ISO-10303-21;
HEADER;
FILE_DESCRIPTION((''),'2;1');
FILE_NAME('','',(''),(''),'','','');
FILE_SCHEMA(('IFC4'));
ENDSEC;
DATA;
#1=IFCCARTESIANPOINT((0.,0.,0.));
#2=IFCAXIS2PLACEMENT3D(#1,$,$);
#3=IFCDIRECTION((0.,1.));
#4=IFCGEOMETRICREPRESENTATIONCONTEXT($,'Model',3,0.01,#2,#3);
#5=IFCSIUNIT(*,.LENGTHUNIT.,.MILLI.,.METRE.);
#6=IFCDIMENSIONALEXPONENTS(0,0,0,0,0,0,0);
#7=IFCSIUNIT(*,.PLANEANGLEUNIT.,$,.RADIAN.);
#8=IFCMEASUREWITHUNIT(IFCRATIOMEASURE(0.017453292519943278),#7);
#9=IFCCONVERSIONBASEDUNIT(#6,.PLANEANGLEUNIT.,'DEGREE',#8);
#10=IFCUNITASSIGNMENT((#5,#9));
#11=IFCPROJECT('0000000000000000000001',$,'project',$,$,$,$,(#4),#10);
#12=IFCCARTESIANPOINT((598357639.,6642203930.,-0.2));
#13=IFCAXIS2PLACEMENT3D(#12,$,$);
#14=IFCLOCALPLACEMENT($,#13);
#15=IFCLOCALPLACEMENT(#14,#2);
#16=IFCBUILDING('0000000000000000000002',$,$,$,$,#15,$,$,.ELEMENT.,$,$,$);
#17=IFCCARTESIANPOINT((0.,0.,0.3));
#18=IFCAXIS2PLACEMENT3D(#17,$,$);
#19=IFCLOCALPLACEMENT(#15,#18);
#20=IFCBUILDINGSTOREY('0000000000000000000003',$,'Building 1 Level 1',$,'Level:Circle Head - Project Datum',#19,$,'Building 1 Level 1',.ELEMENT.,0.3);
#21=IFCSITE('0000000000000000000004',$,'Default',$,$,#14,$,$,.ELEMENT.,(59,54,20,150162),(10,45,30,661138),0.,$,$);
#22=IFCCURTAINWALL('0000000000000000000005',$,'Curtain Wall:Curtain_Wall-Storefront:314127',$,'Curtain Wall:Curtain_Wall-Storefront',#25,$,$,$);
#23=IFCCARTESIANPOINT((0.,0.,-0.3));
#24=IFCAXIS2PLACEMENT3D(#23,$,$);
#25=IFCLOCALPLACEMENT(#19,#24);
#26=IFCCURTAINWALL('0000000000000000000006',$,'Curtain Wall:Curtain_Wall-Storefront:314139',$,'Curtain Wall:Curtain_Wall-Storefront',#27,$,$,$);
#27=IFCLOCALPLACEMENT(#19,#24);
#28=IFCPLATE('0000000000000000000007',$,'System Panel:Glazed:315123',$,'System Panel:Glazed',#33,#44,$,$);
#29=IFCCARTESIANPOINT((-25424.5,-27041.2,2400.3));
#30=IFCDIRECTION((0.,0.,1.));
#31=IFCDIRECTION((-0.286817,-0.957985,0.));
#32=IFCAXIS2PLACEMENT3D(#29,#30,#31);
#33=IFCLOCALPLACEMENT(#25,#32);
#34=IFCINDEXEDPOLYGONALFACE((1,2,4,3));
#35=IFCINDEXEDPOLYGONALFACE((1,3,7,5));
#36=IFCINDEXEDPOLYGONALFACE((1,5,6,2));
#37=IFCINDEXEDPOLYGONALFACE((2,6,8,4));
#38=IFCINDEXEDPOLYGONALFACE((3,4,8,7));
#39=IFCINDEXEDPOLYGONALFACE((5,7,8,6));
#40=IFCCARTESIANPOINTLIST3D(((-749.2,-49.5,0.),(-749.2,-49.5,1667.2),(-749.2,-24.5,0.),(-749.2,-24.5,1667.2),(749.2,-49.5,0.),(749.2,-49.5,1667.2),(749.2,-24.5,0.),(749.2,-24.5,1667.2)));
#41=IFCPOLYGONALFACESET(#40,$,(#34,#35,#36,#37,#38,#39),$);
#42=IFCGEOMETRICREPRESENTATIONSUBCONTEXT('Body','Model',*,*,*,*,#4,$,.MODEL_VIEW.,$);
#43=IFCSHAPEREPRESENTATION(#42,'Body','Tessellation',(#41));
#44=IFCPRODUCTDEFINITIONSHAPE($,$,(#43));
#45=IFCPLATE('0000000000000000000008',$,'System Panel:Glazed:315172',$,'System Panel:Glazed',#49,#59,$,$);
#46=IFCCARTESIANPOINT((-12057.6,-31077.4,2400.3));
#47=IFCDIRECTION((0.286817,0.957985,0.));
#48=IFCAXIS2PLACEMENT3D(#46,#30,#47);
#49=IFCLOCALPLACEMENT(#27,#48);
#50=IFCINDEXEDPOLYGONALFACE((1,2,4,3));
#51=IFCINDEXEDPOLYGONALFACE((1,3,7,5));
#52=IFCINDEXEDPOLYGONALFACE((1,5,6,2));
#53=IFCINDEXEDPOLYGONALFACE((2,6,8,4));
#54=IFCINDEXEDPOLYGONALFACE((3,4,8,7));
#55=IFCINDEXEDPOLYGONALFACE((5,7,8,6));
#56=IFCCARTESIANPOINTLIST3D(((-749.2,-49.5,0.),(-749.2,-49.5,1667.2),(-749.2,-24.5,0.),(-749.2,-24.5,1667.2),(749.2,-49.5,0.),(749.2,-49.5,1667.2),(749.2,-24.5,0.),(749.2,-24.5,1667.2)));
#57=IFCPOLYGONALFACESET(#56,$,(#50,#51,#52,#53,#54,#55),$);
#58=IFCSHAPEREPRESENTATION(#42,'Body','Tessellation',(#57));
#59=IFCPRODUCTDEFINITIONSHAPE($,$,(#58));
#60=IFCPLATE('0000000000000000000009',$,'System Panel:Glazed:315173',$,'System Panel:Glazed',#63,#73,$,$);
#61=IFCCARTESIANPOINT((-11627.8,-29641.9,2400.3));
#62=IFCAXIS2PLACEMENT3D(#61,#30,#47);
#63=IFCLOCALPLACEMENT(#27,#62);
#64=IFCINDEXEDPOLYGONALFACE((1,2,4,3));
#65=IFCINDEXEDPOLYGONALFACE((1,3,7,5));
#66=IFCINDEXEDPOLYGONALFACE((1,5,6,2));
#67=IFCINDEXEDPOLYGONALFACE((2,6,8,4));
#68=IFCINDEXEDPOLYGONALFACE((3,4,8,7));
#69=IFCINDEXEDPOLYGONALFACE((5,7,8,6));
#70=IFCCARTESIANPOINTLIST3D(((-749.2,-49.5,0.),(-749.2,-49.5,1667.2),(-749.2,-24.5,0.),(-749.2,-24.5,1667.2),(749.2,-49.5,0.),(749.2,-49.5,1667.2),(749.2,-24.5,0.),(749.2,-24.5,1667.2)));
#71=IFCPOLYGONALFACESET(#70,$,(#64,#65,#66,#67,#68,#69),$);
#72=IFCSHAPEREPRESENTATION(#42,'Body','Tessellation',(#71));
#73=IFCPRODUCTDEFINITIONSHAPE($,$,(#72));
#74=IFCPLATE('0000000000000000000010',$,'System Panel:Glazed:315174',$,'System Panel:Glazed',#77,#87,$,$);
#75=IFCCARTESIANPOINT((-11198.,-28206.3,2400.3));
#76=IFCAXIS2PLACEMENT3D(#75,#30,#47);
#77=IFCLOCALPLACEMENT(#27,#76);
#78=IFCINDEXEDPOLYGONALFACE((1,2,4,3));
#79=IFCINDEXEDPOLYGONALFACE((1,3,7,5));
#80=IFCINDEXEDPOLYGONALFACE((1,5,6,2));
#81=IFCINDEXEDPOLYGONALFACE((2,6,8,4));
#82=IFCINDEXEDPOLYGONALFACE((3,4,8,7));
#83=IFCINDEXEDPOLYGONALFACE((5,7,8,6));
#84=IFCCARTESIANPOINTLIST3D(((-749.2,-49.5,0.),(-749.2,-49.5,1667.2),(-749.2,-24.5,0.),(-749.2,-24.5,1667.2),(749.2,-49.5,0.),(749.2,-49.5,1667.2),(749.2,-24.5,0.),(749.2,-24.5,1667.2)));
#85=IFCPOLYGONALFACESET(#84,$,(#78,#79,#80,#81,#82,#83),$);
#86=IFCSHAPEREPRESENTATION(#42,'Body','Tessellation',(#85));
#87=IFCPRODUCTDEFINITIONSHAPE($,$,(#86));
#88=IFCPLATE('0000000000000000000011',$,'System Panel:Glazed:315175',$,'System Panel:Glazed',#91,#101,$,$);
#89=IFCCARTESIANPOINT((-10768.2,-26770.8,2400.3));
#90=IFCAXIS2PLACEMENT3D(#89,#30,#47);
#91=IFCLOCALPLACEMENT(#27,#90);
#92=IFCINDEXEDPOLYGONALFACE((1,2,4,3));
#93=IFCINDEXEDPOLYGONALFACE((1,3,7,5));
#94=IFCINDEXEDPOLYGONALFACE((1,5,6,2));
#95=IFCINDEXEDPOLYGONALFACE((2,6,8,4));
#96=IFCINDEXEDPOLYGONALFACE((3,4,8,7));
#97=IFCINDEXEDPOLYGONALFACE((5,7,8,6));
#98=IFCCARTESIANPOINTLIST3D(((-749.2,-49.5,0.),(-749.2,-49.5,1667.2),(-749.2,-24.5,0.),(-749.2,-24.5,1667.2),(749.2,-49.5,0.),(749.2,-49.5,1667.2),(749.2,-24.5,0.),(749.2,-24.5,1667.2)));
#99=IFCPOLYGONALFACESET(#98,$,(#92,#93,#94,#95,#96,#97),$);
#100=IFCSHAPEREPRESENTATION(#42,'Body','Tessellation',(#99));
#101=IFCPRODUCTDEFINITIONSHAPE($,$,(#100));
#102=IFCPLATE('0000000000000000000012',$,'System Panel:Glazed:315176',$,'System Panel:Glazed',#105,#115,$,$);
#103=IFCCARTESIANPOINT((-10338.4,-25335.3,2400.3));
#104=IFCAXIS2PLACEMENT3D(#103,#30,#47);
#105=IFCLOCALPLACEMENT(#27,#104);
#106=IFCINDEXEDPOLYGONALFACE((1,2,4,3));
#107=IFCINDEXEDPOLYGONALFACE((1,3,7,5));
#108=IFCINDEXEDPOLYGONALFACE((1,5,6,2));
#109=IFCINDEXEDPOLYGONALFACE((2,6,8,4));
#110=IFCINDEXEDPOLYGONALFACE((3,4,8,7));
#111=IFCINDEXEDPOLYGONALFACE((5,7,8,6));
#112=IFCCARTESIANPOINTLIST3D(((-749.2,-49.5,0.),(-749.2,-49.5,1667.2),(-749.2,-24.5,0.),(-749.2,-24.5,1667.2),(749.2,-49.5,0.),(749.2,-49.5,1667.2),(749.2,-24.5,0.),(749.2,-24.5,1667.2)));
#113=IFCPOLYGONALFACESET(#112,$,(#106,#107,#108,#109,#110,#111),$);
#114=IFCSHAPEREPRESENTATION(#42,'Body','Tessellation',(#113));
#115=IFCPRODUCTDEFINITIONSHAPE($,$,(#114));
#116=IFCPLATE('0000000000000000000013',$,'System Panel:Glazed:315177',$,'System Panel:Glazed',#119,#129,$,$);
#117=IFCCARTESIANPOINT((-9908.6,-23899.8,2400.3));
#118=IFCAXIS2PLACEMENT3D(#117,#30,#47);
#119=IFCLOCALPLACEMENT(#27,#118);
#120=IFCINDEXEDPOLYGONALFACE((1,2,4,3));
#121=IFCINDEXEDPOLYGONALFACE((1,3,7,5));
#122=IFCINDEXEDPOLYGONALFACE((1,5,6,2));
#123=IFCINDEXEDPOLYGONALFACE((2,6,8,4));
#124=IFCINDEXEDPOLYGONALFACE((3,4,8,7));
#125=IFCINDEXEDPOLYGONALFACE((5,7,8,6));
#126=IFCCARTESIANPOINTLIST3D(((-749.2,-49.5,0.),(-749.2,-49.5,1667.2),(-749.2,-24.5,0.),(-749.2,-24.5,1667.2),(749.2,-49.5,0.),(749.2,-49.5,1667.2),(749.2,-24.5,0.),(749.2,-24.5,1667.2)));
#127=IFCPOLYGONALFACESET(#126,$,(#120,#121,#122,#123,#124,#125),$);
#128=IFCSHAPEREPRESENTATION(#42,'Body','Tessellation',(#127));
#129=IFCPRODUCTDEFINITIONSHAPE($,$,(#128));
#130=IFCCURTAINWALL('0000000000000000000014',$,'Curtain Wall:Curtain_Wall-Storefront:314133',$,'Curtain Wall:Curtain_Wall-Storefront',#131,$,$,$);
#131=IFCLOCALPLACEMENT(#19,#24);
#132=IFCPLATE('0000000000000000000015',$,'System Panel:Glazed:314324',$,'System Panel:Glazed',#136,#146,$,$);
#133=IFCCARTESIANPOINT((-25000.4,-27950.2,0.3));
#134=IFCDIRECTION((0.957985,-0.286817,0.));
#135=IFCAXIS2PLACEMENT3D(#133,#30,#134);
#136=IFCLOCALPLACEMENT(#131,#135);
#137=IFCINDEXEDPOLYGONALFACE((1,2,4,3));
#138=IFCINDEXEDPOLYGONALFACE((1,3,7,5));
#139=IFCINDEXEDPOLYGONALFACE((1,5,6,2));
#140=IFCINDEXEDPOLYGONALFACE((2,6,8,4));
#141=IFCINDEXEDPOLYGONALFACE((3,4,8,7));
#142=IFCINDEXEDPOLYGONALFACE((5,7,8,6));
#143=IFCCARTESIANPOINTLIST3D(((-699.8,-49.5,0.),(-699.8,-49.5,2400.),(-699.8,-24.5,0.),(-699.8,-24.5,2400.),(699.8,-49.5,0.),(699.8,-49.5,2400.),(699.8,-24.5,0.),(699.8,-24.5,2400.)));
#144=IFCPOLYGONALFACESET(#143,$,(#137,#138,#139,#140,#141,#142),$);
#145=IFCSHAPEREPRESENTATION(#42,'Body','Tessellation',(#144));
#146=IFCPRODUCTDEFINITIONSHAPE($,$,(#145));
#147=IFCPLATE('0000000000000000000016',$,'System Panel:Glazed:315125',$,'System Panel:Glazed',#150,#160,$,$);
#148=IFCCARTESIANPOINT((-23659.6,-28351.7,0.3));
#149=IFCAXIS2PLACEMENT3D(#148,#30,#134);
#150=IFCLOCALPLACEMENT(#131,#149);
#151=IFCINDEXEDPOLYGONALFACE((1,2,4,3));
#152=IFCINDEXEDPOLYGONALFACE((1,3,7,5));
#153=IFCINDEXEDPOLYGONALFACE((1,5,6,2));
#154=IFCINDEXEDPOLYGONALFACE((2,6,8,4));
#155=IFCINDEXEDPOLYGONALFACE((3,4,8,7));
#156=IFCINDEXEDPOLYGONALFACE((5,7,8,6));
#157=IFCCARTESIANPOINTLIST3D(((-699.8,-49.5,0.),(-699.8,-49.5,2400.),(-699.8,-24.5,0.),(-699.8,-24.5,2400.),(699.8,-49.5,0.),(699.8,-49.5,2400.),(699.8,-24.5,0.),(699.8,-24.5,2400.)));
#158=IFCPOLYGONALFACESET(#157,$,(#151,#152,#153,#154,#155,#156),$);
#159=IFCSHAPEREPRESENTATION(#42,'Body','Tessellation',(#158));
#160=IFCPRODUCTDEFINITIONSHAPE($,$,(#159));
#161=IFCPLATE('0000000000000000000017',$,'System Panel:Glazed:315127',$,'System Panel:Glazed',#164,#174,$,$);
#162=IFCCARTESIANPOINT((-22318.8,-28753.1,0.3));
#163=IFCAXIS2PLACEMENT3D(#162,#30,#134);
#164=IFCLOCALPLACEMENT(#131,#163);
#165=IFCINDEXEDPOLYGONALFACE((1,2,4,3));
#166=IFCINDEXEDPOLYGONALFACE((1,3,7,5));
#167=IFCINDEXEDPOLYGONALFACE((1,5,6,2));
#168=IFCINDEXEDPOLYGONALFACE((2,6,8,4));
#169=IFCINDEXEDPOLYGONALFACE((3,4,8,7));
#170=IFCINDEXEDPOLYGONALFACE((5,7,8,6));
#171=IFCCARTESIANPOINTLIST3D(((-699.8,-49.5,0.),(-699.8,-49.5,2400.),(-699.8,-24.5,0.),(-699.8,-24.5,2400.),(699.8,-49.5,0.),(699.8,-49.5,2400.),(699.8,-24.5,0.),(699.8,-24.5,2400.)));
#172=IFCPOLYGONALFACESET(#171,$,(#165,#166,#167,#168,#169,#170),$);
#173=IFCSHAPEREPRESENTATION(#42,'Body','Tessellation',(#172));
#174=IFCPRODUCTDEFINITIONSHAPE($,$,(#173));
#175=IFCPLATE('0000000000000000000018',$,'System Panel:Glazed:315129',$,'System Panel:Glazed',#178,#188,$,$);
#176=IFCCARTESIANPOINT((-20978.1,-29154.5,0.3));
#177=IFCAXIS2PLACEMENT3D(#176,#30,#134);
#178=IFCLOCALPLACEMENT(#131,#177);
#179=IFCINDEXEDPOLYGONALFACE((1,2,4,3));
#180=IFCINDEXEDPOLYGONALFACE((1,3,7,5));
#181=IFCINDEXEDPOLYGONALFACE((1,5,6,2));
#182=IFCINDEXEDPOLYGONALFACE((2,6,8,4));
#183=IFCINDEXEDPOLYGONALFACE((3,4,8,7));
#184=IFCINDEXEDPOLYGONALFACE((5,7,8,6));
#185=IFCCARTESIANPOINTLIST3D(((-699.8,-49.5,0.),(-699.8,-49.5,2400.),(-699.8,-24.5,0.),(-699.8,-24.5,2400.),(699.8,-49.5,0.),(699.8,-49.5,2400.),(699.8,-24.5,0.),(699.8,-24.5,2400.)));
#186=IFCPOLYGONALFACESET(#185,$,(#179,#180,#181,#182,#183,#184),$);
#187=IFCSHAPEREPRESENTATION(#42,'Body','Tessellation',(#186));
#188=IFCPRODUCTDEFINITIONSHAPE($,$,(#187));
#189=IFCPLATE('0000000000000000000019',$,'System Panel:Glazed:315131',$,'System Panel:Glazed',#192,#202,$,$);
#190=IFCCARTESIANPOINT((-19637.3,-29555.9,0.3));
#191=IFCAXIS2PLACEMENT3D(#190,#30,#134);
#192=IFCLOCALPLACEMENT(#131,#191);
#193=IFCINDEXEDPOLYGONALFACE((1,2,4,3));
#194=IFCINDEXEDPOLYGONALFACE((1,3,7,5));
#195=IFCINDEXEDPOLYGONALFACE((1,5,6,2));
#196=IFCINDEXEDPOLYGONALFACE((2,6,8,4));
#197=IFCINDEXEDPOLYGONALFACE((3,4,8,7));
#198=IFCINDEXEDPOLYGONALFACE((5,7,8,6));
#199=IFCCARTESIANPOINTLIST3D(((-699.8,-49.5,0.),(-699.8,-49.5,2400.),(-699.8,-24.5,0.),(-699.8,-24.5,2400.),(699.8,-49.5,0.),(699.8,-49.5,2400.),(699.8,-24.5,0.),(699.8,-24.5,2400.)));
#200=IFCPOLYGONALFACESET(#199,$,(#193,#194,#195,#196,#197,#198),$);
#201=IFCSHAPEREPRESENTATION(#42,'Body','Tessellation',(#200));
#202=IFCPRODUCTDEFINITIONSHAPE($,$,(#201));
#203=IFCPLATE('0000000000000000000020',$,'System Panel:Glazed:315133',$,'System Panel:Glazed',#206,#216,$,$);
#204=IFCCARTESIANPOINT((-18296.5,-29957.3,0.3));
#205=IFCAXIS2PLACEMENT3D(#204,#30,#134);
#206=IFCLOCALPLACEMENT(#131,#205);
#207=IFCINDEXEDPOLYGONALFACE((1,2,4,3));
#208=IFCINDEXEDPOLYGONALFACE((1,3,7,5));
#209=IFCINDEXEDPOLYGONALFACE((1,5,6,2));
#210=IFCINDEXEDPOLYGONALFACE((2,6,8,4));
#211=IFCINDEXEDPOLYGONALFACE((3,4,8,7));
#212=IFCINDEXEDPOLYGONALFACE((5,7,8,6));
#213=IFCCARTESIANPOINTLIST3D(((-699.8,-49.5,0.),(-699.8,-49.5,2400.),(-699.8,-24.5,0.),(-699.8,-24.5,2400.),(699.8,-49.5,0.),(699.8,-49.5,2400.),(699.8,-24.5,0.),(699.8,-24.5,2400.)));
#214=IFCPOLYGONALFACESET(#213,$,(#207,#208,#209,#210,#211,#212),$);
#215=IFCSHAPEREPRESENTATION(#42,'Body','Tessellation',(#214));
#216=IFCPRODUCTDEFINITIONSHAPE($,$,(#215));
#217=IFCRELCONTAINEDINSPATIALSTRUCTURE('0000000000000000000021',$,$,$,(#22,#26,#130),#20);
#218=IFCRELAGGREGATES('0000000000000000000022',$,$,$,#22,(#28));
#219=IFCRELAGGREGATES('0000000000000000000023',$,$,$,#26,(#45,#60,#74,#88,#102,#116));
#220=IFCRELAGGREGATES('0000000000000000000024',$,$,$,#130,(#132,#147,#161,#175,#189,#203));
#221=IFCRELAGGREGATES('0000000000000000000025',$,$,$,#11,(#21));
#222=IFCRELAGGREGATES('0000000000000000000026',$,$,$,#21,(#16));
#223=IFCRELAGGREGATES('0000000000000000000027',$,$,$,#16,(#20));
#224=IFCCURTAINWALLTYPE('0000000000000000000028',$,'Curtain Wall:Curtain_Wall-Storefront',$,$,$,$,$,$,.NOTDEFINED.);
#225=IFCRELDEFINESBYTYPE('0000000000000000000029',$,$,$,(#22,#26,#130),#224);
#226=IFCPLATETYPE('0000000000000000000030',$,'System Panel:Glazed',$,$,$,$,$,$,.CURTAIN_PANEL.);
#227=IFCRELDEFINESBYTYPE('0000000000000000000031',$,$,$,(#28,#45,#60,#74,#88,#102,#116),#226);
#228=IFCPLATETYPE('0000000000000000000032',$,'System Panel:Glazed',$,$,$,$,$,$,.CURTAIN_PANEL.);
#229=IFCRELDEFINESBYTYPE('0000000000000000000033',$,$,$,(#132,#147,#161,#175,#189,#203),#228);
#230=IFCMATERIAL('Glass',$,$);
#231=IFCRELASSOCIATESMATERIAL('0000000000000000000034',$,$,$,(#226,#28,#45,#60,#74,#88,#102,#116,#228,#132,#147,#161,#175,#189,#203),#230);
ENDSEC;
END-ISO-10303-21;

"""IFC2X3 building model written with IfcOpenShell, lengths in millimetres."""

from ifc_helpers import new_model, entity, si_unit, converted_unit, direction, frame, frame_2d, origin, place, context, subcontext, project, spatial, rectangle, extrude, source, transform, mapped, material, type_object, type_shapes, element, aggregate, save


model = new_model("IFC2X3")

# Units and contexts
model_context = context("Model", 3, precision=0.01, world=origin(), true_north=direction((0.0, 1.0)))
body_context = subcontext(model_context, "Body", "Model", "MODEL_VIEW")
ifc_project = project(units=[si_unit("LENGTHUNIT", "METRE", prefix="MILLI"), converted_unit("PLANEANGLEUNIT", "DEGREE", entity("IfcRatioMeasure", 0.017453292519943278), si_unit("PLANEANGLEUNIT", "RADIAN"), dimensions=[0, 0, 0, 0, 0, 0, 0])], contexts=[model_context])

# Site, building, storey
site_placement = place(None, frame((598357639.0, 6642203930.0, -0.2)))
site = spatial("IfcSite", under=ifc_project, at=site_placement, Name="Default", CompositionType="ELEMENT", RefLatitude=(59, 54, 20, 150162), RefLongitude=(10, 45, 30, 661138), RefElevation=0.0)
building_placement = place(site_placement, origin())
building = spatial("IfcBuilding", under=site, at=building_placement, CompositionType="ELEMENT")
storey_placement = place(building_placement, frame((0.0, 0.0, 0.3)))
storey = spatial("IfcBuildingStorey", under=building, at=storey_placement, Name="Building 1 Level 1", ObjectType="Level:Circle Head - Project Datum", LongName="Building 1 Level 1", CompositionType="ELEMENT", Elevation=0.3)

# Curtain walls
curtain_wall_type = type_object("IfcCurtainWallType", Name="Curtain Wall:Curtain_Wall-Storefront", PredefinedType="NOTDEFINED")
curtain_wall_1_placement = place(storey_placement, frame((0.0, 0.0, -0.3)))
curtain_wall_1 = element("IfcCurtainWall", 1, at=curtain_wall_1_placement, inside=storey, type_object=curtain_wall_type, Name="Curtain Wall:Curtain_Wall-Storefront:314127", ObjectType="Curtain Wall:Curtain_Wall-Storefront")
ifc_material = material(Name="Glass")
curtain_wall_2_placement = place(storey_placement, frame((0.0, 0.0, -0.3)))
curtain_wall_2 = element("IfcCurtainWall", 2, at=curtain_wall_2_placement, inside=storey, type_object=curtain_wall_type, Name="Curtain Wall:Curtain_Wall-Storefront:314139", ObjectType="Curtain Wall:Curtain_Wall-Storefront")

# Plates
plate_type_1 = type_object("IfcPlateType", Name="System Panel:Glazed", PredefinedType="CURTAIN_PANEL", material=ifc_material)
shared_shape_1 = source(origin(), body_context, "Body", "SweptSolid", [
    extrude(rectangle(XDim=25.0, YDim=1498.5, at=frame_2d((0.0, 0.0), x_axis=(1.0, 0.0))), frame((0.0, -37.0, 0.0), z_axis=(0.0, 0.0, 1.0), x_axis=(0.0, 1.0, 0.0)), (0.0, 0.0, 1.0), 1667.2),
])
type_shapes(plate_type_1, [shared_shape_1])
plate_1_placement = place(curtain_wall_1_placement, frame((-25424.5, -27041.2, 2400.3), z_axis=(0.0, 0.0, 1.0), x_axis=(-0.286817, -0.957985, 0.0)))
plate_1 = element("IfcPlate", 3, at=plate_1_placement, type_object=plate_type_1, material=ifc_material, Name="System Panel:Glazed:315123", ObjectType="System Panel:Glazed", context=body_context, shape_type="MappedRepresentation", body=[
    mapped(shared_shape_1, transform((0.0, 0.0, 0.0), scale=1.0)),
])
aggregate(curtain_wall_1, [plate_1])
plate_2_placement = place(curtain_wall_2_placement, frame((-12057.6, -31077.4, 2400.3), z_axis=(0.0, 0.0, 1.0), x_axis=(0.286817, 0.957985, 0.0)))
plate_2 = element("IfcPlate", 4, at=plate_2_placement, type_object=plate_type_1, material=ifc_material, Name="System Panel:Glazed:315172", ObjectType="System Panel:Glazed", context=body_context, shape_type="MappedRepresentation", body=[
    mapped(shared_shape_1, transform((0.0, 0.0, 0.0), scale=1.0)),
])
plate_3_placement = place(curtain_wall_2_placement, frame((-11627.8, -29641.9, 2400.3), z_axis=(0.0, 0.0, 1.0), x_axis=(0.286817, 0.957985, 0.0)))
plate_3 = element("IfcPlate", 5, at=plate_3_placement, type_object=plate_type_1, material=ifc_material, Name="System Panel:Glazed:315173", ObjectType="System Panel:Glazed", context=body_context, shape_type="MappedRepresentation", body=[
    mapped(shared_shape_1, transform((0.0, 0.0, 0.0), scale=1.0)),
])
plate_4_placement = place(curtain_wall_2_placement, frame((-11198.0, -28206.3, 2400.3), z_axis=(0.0, 0.0, 1.0), x_axis=(0.286817, 0.957985, 0.0)))
plate_4 = element("IfcPlate", 6, at=plate_4_placement, type_object=plate_type_1, material=ifc_material, Name="System Panel:Glazed:315174", ObjectType="System Panel:Glazed", context=body_context, shape_type="MappedRepresentation", body=[
    mapped(shared_shape_1, transform((0.0, 0.0, 0.0), scale=1.0)),
])
plate_5_placement = place(curtain_wall_2_placement, frame((-10768.2, -26770.8, 2400.3), z_axis=(0.0, 0.0, 1.0), x_axis=(0.286817, 0.957985, 0.0)))
plate_5 = element("IfcPlate", 7, at=plate_5_placement, type_object=plate_type_1, material=ifc_material, Name="System Panel:Glazed:315175", ObjectType="System Panel:Glazed", context=body_context, shape_type="MappedRepresentation", body=[
    mapped(shared_shape_1, transform((0.0, 0.0, 0.0), scale=1.0)),
])
plate_6_placement = place(curtain_wall_2_placement, frame((-10338.4, -25335.3, 2400.3), z_axis=(0.0, 0.0, 1.0), x_axis=(0.286817, 0.957985, 0.0)))
plate_6 = element("IfcPlate", 8, at=plate_6_placement, type_object=plate_type_1, material=ifc_material, Name="System Panel:Glazed:315176", ObjectType="System Panel:Glazed", context=body_context, shape_type="MappedRepresentation", body=[
    mapped(shared_shape_1, transform((0.0, 0.0, 0.0), scale=1.0)),
])
plate_7_placement = place(curtain_wall_2_placement, frame((-9908.6, -23899.8, 2400.3), z_axis=(0.0, 0.0, 1.0), x_axis=(0.286817, 0.957985, 0.0)))
plate_7 = element("IfcPlate", 9, at=plate_7_placement, type_object=plate_type_1, material=ifc_material, Name="System Panel:Glazed:315177", ObjectType="System Panel:Glazed", context=body_context, shape_type="MappedRepresentation", body=[
    mapped(shared_shape_1, transform((0.0, 0.0, 0.0), scale=1.0)),
])
aggregate(curtain_wall_2, [plate_2, plate_3, plate_4, plate_5, plate_6, plate_7])

# Curtain wall, plates
curtain_wall_3_placement = place(storey_placement, frame((0.0, 0.0, -0.3)))
curtain_wall_3 = element("IfcCurtainWall", 10, at=curtain_wall_3_placement, inside=storey, type_object=curtain_wall_type, Name="Curtain Wall:Curtain_Wall-Storefront:314133", ObjectType="Curtain Wall:Curtain_Wall-Storefront")
plate_type_2 = type_object("IfcPlateType", Name="System Panel:Glazed", PredefinedType="CURTAIN_PANEL", material=ifc_material)
shared_shape_2 = source(origin(), body_context, "Body", "SweptSolid", [
    extrude(rectangle(XDim=25.0, YDim=1399.6, at=frame_2d((0.0, 0.0), x_axis=(1.0, 0.0))), frame((0.0, -37.0, 0.0), z_axis=(0.0, 0.0, 1.0), x_axis=(0.0, 1.0, 0.0)), (0.0, 0.0, 1.0), 2400.0),
])
type_shapes(plate_type_2, [shared_shape_2])
plate_8_placement = place(curtain_wall_3_placement, frame((-25000.4, -27950.2, 0.3), z_axis=(0.0, 0.0, 1.0), x_axis=(0.957985, -0.286817, 0.0)))
plate_8 = element("IfcPlate", 11, at=plate_8_placement, type_object=plate_type_2, material=ifc_material, Name="System Panel:Glazed:314324", ObjectType="System Panel:Glazed", context=body_context, shape_type="MappedRepresentation", body=[
    mapped(shared_shape_2, transform((0.0, 0.0, 0.0), scale=1.0)),
])
plate_9_placement = place(curtain_wall_3_placement, frame((-23659.6, -28351.7, 0.3), z_axis=(0.0, 0.0, 1.0), x_axis=(0.957985, -0.286817, 0.0)))
plate_9 = element("IfcPlate", 12, at=plate_9_placement, type_object=plate_type_2, material=ifc_material, Name="System Panel:Glazed:315125", ObjectType="System Panel:Glazed", context=body_context, shape_type="MappedRepresentation", body=[
    mapped(shared_shape_2, transform((0.0, 0.0, 0.0), scale=1.0)),
])
plate_10_placement = place(curtain_wall_3_placement, frame((-22318.8, -28753.1, 0.3), z_axis=(0.0, 0.0, 1.0), x_axis=(0.957985, -0.286817, 0.0)))
plate_10 = element("IfcPlate", 13, at=plate_10_placement, type_object=plate_type_2, material=ifc_material, Name="System Panel:Glazed:315127", ObjectType="System Panel:Glazed", context=body_context, shape_type="MappedRepresentation", body=[
    mapped(shared_shape_2, transform((0.0, 0.0, 0.0), scale=1.0)),
])
plate_11_placement = place(curtain_wall_3_placement, frame((-20978.1, -29154.5, 0.3), z_axis=(0.0, 0.0, 1.0), x_axis=(0.957985, -0.286817, 0.0)))
plate_11 = element("IfcPlate", 14, at=plate_11_placement, type_object=plate_type_2, material=ifc_material, Name="System Panel:Glazed:315129", ObjectType="System Panel:Glazed", context=body_context, shape_type="MappedRepresentation", body=[
    mapped(shared_shape_2, transform((0.0, 0.0, 0.0), scale=1.0)),
])
plate_12_placement = place(curtain_wall_3_placement, frame((-19637.3, -29555.9, 0.3), z_axis=(0.0, 0.0, 1.0), x_axis=(0.957985, -0.286817, 0.0)))
plate_12 = element("IfcPlate", 15, at=plate_12_placement, type_object=plate_type_2, material=ifc_material, Name="System Panel:Glazed:315131", ObjectType="System Panel:Glazed", context=body_context, shape_type="MappedRepresentation", body=[
    mapped(shared_shape_2, transform((0.0, 0.0, 0.0), scale=1.0)),
])
plate_13_placement = place(curtain_wall_3_placement, frame((-18296.5, -29957.3, 0.3), z_axis=(0.0, 0.0, 1.0), x_axis=(0.957985, -0.286817, 0.0)))
plate_13 = element("IfcPlate", 16, at=plate_13_placement, type_object=plate_type_2, material=ifc_material, Name="System Panel:Glazed:315133", ObjectType="System Panel:Glazed", context=body_context, shape_type="MappedRepresentation", body=[
    mapped(shared_shape_2, transform((0.0, 0.0, 0.0), scale=1.0)),
])
aggregate(curtain_wall_3, [plate_8, plate_9, plate_10, plate_11, plate_12, plate_13])

save(model, "model.ifc")
